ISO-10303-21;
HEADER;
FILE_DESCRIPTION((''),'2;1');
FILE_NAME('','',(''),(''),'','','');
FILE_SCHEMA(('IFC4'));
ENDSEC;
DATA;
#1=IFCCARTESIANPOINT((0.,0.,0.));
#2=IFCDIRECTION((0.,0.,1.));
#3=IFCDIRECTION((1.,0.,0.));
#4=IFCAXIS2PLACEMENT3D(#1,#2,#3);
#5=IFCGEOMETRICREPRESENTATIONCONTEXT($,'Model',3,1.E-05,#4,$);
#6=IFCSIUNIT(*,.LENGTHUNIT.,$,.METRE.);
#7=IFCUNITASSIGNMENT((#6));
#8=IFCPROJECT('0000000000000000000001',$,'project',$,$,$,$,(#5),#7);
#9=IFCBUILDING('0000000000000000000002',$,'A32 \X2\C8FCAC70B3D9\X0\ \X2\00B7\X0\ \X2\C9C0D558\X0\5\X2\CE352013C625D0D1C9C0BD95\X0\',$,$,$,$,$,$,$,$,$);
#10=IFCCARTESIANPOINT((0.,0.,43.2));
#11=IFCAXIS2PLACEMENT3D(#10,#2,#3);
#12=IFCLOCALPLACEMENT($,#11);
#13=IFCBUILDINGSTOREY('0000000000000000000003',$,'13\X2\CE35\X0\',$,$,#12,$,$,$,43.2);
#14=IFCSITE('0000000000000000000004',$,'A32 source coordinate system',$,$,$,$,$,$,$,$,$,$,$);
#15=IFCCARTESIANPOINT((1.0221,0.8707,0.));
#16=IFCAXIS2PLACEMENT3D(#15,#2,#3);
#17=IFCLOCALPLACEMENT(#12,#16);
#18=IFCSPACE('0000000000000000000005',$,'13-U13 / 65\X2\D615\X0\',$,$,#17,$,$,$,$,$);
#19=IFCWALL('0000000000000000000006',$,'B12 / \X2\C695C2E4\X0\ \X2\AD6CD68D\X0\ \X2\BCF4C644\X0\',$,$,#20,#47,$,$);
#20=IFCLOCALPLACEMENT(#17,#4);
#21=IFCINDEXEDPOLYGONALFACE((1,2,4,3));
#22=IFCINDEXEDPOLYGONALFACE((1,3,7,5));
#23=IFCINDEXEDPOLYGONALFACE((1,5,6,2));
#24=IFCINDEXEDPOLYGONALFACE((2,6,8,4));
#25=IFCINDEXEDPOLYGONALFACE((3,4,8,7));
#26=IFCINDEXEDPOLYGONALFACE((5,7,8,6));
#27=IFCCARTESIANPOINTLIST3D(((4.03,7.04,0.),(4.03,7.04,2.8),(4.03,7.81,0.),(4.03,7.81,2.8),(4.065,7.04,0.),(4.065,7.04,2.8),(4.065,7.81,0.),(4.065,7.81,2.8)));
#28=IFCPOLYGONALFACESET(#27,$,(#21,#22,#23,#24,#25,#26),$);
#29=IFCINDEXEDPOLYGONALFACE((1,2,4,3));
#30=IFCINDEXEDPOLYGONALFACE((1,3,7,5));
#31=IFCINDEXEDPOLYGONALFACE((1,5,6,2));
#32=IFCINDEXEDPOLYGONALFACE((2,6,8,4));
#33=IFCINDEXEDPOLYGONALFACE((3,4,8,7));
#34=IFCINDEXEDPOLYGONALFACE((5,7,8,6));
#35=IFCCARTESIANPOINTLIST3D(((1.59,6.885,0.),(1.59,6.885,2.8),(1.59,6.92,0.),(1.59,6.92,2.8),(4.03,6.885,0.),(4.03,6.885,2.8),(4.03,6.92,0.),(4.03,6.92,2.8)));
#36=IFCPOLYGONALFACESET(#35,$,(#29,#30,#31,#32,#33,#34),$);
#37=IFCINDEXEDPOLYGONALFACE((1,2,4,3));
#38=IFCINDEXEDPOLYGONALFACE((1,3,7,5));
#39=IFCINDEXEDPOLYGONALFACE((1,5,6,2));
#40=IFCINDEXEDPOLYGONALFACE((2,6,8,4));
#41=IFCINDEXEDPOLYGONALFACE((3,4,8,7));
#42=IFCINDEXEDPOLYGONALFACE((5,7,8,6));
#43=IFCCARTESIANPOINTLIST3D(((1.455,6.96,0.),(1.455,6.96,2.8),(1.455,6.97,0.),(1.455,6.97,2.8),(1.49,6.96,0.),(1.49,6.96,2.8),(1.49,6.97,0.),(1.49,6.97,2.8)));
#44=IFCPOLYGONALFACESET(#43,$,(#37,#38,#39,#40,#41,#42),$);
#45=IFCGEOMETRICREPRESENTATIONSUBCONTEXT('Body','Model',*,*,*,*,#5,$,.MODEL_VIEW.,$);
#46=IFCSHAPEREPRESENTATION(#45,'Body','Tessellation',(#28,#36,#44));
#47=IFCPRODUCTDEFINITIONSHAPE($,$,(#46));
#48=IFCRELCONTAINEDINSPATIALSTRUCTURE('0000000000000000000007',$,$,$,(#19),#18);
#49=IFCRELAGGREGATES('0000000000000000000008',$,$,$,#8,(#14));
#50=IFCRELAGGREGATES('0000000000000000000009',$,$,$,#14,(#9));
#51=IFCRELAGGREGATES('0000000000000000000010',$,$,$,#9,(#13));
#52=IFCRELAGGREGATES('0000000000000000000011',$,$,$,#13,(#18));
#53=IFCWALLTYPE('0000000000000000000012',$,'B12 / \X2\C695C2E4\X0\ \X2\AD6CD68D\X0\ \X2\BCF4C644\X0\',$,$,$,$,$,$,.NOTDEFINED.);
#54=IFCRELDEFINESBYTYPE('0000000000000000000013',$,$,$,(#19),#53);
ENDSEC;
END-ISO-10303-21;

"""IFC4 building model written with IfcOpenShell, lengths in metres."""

from ifc_helpers import new_model, si_unit, frame, origin, origin_with_axes, place, context, subcontext, project, spatial, polyline, outline, extrude, source, transform, mapped, type_object, type_shapes, element, save


model = new_model("IFC4")

# Units and contexts
model_context = context("Model", 3, precision=1e-05, world=origin_with_axes())
body_context = subcontext(model_context, "Body", "Model", "MODEL_VIEW")
ifc_project = project(units=[si_unit("LENGTHUNIT", "METRE")], contexts=[model_context])

# Site, building, storey, space
storey_placement = place(None, frame((0.0, 0.0, 43.2), z_axis=(0.0, 0.0, 1.0), x_axis=(1.0, 0.0, 0.0)))
space_placement = place(storey_placement, frame((1.0221, 0.8707, 0.0), z_axis=(0.0, 0.0, 1.0), x_axis=(1.0, 0.0, 0.0)))
site = spatial("IfcSite", under=ifc_project, Name="A32 source coordinate system")
building = spatial("IfcBuilding", under=site, Name="A32 주거동 · 지하5층–옥탑지붕")
storey = spatial("IfcBuildingStorey", under=building, at=storey_placement, Name="13층", Elevation=43.2)
space = spatial("IfcSpace", under=storey, at=space_placement, Name="13-U13 / 65형")

# Wall
wall_type_1 = type_object("IfcWallType", Name="B12 / 욕실 구획 보완", PredefinedType="NOTDEFINED")
shared_shape_1 = source(origin(), body_context, "Body", "SweptSolid", [
    extrude(outline(polyline([(4.065, 7.04), (4.03, 7.04), (4.03, 7.81), (4.065, 7.81), (4.065, 7.04)])), origin(), (0.0, 0.0, 1.0), 2.8),
    extrude(outline(polyline([(1.59, 6.92), (4.03, 6.92), (4.03, 6.885), (1.59, 6.885), (1.59, 6.92)])), origin(), (0.0, 0.0, 1.0), 2.8),
    extrude(outline(polyline([(1.455, 6.97), (1.49, 6.97), (1.49, 6.96), (1.455, 6.96), (1.455, 6.97)])), origin(), (0.0, 0.0, 1.0), 2.8),
])
type_shapes(wall_type_1, [shared_shape_1])
wall_1_placement = place(space_placement, origin_with_axes())
element("IfcWall", 1, at=wall_1_placement, inside=space, type_object=wall_type_1, Name="B12 / 욕실 구획 보완", context=body_context, shape_type="MappedRepresentation", body=[
    mapped(shared_shape_1, transform((0.0, 0.0, 0.0), scale=1.0)),
])

save(model, "model.ifc")
